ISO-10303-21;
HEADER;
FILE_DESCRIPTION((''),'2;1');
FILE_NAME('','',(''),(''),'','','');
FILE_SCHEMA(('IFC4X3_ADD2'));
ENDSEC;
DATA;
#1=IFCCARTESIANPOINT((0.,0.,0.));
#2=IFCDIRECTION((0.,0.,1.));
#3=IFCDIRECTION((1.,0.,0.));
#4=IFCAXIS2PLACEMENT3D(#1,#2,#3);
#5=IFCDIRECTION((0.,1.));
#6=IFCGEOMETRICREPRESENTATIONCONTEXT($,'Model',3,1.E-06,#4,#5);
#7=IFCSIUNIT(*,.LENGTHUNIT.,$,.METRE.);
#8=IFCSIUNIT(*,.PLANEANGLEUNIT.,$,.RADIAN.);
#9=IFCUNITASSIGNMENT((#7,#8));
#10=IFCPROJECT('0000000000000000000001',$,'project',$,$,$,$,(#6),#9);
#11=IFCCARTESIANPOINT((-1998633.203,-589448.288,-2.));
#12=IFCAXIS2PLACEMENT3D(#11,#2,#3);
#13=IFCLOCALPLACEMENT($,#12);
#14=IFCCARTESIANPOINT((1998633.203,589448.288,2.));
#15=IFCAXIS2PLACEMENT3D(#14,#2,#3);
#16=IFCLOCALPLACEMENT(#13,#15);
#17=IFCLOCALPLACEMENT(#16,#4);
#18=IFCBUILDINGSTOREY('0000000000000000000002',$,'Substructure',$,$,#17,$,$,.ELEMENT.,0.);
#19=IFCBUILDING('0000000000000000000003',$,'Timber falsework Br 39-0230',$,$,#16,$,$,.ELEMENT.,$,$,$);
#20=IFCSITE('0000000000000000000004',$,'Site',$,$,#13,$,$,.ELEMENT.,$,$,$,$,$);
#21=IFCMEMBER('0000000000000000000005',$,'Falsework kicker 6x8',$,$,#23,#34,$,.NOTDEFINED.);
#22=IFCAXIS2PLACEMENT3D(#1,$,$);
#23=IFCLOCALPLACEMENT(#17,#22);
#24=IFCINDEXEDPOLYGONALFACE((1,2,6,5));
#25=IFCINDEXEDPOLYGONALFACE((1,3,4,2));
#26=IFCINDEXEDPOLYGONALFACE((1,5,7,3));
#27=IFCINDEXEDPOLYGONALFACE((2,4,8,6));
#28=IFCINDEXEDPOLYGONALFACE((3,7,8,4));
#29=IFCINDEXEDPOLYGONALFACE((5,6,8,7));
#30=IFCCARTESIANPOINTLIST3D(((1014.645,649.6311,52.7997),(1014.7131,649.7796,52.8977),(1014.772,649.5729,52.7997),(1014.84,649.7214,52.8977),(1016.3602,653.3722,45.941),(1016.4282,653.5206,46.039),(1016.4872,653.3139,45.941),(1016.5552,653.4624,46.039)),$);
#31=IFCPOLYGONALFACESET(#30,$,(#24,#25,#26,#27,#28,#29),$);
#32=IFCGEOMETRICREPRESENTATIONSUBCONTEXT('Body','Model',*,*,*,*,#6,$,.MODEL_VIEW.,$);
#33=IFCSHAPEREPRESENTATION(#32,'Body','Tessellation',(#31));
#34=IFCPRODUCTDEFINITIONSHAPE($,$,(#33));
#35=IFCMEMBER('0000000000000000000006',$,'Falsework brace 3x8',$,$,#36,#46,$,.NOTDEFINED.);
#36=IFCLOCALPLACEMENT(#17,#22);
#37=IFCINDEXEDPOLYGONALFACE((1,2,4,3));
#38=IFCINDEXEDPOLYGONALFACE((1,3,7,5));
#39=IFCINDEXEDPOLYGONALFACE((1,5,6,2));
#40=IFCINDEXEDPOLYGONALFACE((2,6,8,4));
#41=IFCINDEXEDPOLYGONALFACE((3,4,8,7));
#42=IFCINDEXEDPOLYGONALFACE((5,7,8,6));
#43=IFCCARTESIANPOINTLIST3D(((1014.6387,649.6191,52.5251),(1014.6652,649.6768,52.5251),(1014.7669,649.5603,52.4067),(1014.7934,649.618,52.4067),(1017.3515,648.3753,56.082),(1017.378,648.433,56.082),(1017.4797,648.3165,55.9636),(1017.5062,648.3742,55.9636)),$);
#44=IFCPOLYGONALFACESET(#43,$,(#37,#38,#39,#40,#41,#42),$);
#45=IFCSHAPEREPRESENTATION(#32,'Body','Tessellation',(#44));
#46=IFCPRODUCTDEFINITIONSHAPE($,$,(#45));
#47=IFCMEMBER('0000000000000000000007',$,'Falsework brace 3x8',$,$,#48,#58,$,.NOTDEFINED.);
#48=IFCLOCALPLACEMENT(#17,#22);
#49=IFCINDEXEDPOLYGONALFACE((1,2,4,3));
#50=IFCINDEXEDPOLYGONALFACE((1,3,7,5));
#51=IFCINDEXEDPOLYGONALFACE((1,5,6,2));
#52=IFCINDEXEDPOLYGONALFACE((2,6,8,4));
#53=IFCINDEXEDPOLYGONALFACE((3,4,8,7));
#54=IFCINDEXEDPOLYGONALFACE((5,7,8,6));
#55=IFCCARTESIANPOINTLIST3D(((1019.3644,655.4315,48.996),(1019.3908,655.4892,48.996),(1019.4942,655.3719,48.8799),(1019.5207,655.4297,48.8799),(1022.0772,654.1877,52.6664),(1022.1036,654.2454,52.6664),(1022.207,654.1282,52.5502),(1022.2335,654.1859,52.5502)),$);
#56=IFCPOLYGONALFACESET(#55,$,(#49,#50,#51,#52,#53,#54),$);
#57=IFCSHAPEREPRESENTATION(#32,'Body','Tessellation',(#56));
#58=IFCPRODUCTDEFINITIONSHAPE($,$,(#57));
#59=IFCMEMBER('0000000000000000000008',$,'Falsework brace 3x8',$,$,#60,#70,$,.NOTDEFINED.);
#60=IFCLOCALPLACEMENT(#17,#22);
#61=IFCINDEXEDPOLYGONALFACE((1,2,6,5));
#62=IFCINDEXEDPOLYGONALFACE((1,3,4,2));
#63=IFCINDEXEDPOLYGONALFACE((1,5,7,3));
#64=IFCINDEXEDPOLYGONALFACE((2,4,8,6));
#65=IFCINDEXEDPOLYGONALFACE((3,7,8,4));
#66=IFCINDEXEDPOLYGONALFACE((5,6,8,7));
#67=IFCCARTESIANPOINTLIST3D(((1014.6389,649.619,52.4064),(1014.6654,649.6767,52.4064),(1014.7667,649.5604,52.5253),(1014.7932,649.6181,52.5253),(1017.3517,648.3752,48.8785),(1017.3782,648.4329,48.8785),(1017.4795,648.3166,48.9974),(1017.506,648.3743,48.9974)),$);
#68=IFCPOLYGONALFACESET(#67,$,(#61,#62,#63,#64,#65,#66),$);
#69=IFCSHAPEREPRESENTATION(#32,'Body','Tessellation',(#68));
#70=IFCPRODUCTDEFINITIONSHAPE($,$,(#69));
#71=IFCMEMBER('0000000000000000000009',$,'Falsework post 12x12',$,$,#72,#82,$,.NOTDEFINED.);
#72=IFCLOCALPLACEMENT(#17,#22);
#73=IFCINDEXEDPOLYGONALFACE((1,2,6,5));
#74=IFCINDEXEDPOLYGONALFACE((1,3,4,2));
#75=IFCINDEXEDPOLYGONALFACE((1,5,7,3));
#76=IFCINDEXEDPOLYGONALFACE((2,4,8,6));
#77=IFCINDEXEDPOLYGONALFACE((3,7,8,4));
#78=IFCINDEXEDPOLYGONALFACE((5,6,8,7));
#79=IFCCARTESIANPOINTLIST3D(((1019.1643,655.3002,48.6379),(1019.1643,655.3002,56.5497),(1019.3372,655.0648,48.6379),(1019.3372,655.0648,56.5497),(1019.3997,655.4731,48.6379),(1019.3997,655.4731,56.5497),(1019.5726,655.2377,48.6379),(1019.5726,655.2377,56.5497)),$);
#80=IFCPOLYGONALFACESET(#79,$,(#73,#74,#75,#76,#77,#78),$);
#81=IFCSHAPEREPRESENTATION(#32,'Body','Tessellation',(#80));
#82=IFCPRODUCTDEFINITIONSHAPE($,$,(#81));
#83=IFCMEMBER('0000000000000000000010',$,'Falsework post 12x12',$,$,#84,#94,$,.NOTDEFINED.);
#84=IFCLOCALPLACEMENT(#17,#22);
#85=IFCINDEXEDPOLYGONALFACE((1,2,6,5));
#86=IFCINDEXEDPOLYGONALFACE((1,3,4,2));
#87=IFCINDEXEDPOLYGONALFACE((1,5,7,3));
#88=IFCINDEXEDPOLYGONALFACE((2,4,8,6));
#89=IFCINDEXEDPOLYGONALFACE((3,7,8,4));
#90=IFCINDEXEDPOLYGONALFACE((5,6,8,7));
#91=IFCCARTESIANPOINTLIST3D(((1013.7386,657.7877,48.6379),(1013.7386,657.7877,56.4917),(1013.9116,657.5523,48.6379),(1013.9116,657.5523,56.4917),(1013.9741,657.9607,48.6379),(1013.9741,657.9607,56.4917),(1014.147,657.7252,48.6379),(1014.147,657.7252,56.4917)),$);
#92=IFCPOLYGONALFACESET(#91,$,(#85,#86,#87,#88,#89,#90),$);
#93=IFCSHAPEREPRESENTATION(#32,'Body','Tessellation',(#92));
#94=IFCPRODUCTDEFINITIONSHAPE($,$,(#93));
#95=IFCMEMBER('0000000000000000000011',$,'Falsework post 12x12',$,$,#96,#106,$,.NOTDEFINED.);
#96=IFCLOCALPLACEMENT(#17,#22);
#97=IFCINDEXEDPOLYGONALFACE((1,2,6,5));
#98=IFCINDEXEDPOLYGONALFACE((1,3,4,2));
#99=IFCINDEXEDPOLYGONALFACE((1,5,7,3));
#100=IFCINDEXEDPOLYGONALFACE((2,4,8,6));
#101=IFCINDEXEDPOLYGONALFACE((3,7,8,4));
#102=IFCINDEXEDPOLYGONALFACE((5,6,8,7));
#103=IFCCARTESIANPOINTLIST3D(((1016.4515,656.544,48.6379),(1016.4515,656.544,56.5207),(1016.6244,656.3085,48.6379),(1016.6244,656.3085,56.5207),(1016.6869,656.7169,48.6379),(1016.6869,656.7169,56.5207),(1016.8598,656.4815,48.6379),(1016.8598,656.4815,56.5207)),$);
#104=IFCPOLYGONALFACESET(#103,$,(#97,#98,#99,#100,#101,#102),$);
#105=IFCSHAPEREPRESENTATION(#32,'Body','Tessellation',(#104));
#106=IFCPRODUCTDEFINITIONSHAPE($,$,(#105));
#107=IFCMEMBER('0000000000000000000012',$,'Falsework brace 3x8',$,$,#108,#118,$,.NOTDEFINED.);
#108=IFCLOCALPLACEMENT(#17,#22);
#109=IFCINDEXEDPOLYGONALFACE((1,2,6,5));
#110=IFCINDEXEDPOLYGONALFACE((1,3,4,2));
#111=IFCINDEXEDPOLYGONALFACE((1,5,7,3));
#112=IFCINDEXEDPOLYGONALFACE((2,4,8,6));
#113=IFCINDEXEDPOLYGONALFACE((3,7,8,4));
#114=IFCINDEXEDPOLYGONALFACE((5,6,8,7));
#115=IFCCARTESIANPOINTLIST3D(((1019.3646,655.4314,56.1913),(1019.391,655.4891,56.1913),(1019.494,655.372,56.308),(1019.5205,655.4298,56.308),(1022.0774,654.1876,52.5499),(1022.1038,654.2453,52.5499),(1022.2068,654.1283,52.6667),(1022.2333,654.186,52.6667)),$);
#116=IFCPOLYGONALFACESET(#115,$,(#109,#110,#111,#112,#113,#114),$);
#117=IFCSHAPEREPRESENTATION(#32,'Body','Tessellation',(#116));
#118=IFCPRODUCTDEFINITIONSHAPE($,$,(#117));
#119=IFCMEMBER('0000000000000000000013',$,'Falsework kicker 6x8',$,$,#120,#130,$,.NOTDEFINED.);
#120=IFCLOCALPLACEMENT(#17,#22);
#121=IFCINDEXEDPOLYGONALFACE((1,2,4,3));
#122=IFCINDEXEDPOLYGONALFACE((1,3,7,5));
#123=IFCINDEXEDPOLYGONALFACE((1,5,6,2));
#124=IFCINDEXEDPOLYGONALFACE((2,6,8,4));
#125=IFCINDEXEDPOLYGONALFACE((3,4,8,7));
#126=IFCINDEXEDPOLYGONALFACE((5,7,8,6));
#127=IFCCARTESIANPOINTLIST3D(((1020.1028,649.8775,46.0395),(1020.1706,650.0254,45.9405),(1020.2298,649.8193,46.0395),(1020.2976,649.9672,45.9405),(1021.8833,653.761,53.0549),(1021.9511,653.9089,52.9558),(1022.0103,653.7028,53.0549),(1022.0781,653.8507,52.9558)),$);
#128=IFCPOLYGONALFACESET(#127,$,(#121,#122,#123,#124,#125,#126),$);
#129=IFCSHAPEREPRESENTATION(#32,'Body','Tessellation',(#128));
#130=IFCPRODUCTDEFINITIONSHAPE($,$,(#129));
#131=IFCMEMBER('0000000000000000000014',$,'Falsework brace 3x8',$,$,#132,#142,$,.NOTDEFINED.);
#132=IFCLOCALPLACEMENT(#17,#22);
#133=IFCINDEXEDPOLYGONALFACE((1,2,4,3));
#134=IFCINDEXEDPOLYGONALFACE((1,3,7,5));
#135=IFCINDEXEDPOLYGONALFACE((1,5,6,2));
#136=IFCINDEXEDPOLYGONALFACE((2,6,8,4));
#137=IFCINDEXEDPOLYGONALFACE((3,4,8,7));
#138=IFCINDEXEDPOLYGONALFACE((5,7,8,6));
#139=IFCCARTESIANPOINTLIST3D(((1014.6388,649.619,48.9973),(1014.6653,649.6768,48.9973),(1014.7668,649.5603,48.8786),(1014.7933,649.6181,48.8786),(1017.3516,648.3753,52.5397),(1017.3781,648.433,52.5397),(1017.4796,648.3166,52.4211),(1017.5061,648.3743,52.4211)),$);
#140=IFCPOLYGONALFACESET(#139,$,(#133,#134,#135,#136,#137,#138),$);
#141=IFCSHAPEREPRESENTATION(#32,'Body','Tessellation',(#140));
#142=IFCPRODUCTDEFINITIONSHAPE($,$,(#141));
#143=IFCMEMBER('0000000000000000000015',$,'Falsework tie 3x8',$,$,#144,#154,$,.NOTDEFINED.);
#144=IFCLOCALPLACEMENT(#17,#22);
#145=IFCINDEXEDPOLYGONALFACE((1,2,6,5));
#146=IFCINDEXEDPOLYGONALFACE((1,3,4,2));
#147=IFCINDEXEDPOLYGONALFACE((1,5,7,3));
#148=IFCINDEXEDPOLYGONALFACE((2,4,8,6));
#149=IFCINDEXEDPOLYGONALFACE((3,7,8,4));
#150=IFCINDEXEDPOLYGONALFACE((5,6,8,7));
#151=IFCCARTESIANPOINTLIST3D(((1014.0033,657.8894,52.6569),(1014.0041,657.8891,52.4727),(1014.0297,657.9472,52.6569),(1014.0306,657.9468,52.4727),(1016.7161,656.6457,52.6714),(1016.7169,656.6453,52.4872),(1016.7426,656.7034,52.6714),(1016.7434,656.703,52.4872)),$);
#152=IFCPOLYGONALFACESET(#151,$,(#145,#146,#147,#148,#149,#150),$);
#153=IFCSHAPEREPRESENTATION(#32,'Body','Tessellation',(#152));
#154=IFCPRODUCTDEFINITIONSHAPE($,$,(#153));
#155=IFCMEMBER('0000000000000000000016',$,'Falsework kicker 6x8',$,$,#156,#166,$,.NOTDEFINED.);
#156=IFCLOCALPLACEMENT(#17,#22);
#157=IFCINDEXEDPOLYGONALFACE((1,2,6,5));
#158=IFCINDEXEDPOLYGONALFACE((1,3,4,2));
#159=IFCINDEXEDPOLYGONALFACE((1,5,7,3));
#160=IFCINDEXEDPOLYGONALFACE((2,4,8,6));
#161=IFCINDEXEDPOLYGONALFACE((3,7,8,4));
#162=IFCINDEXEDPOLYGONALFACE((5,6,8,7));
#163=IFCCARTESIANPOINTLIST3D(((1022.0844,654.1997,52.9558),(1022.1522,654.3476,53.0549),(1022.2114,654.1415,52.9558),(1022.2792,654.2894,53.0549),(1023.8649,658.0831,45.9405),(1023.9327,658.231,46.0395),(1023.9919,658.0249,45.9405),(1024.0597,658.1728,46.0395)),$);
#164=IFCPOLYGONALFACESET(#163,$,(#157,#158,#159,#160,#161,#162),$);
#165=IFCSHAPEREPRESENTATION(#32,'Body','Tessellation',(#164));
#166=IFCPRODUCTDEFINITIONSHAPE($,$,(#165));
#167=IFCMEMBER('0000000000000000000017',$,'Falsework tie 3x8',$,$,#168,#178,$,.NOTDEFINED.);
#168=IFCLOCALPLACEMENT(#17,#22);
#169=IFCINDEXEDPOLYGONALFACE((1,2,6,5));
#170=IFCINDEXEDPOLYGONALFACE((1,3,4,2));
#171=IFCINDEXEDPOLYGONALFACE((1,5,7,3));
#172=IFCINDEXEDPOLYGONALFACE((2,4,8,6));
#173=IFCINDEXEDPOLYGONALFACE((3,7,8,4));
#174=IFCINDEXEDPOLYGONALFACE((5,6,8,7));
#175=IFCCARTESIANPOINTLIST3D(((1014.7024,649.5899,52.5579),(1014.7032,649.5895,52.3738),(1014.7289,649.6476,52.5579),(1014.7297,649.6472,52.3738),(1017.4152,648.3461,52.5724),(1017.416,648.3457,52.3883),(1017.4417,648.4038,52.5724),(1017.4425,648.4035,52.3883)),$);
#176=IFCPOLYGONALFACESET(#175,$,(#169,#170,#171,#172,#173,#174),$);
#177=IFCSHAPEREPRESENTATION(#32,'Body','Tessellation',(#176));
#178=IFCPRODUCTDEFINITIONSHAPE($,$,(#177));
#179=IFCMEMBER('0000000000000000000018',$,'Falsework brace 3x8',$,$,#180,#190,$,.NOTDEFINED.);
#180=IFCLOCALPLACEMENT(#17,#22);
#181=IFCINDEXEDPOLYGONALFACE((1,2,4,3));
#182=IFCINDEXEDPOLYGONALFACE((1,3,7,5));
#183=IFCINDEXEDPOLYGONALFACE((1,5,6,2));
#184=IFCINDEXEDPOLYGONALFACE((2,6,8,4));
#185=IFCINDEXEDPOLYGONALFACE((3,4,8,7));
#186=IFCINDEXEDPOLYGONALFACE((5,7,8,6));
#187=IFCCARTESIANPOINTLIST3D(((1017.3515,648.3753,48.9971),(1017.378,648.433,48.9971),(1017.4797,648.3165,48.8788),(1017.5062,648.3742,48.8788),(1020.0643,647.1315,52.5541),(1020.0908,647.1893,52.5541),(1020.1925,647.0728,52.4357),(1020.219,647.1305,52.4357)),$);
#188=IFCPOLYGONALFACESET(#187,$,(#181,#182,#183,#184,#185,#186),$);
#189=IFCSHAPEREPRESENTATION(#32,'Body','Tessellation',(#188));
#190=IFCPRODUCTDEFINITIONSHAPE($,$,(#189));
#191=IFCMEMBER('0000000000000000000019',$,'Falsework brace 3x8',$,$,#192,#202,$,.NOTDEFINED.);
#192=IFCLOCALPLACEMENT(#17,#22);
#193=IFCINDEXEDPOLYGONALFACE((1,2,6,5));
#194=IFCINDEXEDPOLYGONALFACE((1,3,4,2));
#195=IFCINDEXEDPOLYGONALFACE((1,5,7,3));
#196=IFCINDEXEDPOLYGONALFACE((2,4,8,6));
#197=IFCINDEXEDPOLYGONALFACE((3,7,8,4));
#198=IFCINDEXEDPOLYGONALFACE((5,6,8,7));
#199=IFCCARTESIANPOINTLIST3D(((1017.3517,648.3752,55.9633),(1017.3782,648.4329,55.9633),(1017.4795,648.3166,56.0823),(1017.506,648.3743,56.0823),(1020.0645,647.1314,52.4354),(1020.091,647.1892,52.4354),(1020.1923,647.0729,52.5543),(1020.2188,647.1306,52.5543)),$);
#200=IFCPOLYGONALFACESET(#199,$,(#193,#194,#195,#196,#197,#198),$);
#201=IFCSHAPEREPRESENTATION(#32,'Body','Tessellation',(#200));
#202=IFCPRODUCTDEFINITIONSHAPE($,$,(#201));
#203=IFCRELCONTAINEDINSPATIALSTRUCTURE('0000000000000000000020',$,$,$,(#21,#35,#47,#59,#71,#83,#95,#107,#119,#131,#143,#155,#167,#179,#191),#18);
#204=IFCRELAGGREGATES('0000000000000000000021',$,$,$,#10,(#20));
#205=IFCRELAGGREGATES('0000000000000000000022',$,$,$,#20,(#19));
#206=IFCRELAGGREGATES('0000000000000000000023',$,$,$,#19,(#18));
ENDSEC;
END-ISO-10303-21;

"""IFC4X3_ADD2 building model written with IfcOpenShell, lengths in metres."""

from ifc_helpers import new_model, si_unit, direction, frame, origin, origin_with_axes, origin_2d, place, context, subcontext, project, spatial, rectangle, extrude, element, save


model = new_model("IFC4X3_ADD2")

# Units and contexts
model_context = context("Model", 3, precision=1e-06, world=origin_with_axes(), true_north=direction((0.0, 1.0)))
body_context = subcontext(model_context, "Body", "Model", "MODEL_VIEW")
ifc_project = project(units=[si_unit("LENGTHUNIT", "METRE"), si_unit("PLANEANGLEUNIT", "RADIAN")], contexts=[model_context])

# Site, building, storey
site_placement = place(None, frame((-1998633.203, -589448.288, -2.0), z_axis=(0.0, 0.0, 1.0), x_axis=(1.0, 0.0, 0.0)))
site = spatial("IfcSite", under=ifc_project, at=site_placement, Name="Site", CompositionType="ELEMENT")
building_placement = place(site_placement, frame((1998633.203, 589448.288, 2.0), z_axis=(0.0, 0.0, 1.0), x_axis=(1.0, 0.0, 0.0)))
building = spatial("IfcBuilding", under=site, at=building_placement, Name="Timber falsework Br 39-0230", CompositionType="ELEMENT")
storey_placement = place(building_placement, origin_with_axes())
storey = spatial("IfcBuildingStorey", under=building, at=storey_placement, Name="Substructure", CompositionType="ELEMENT", Elevation=0.0)

# Members
member_1_placement = place(storey_placement, frame((1014.7425, 649.6763, 52.8487), z_axis=(0.214434, 0.467707, -0.857478), x_axis=(-0.909014, 0.416765, 0.0)))
element("IfcMember", 1, at=member_1_placement, inside=storey, Name="Falsework kicker 6x8", PredefinedType="NOTDEFINED", context=body_context, shape_type="SweptSolid", body=[
    extrude(rectangle(XDim=0.1397, YDim=0.1905, at=origin_2d()), origin(), (0.0, 0.0, 1.0), 7.9987),
])
member_2_placement = place(storey_placement, frame((1014.716, 649.6185, 52.4659), z_axis=(0.584271, -0.267877, 0.766074), x_axis=(0.416765, 0.909014, 0.0)))
element("IfcMember", 2, at=member_2_placement, inside=storey, Name="Falsework brace 3x8", PredefinedType="NOTDEFINED", context=body_context, shape_type="SweptSolid", body=[
    extrude(rectangle(XDim=0.0635, YDim=0.1841, at=origin_2d()), origin(), (0.0, 0.0, 1.0), 4.6431),
])
member_3_placement = place(storey_placement, frame((1019.4425, 655.4306, 48.9379), z_axis=(0.573468, -0.262924, 0.77589), x_axis=(0.416765, 0.909014, 0.0)))
element("IfcMember", 3, at=member_3_placement, inside=storey, Name="Falsework brace 3x8", PredefinedType="NOTDEFINED", context=body_context, shape_type="SweptSolid", body=[
    extrude(rectangle(XDim=0.0635, YDim=0.1841, at=origin_2d()), origin(), (0.0, 0.0, 1.0), 4.7305),
])
member_4_placement = place(storey_placement, frame((1014.716, 649.6185, 52.4659), z_axis=(0.587075, -0.269162, -0.763475), x_axis=(0.416765, 0.909014, 0.0)))
element("IfcMember", 4, at=member_4_placement, inside=storey, Name="Falsework brace 3x8", PredefinedType="NOTDEFINED", context=body_context, shape_type="SweptSolid", body=[
    extrude(rectangle(XDim=0.0635, YDim=0.1841, at=origin_2d()), origin(), (0.0, 0.0, 1.0), 4.6209),
])
member_5_placement = place(storey_placement, frame((1019.3684, 655.2689, 48.6379), z_axis=(0.0, 0.0, 1.0), x_axis=(-0.805928, -0.592013, 0.0)))
element("IfcMember", 5, at=member_5_placement, inside=storey, Name="Falsework post 12x12", PredefinedType="NOTDEFINED", context=body_context, shape_type="SweptSolid", body=[
    extrude(rectangle(XDim=0.2921, YDim=0.2921, at=origin_2d()), origin(), (0.0, 0.0, 1.0), 7.9117),
])
member_6_placement = place(storey_placement, frame((1013.9428, 657.7565, 48.6379), z_axis=(0.0, 0.0, 1.0), x_axis=(-0.805928, -0.592013, 0.0)))
element("IfcMember", 6, at=member_6_placement, inside=storey, Name="Falsework post 12x12", PredefinedType="NOTDEFINED", context=body_context, shape_type="SweptSolid", body=[
    extrude(rectangle(XDim=0.2921, YDim=0.2921, at=origin_2d()), origin(), (0.0, 0.0, 1.0), 7.8537),
])
member_7_placement = place(storey_placement, frame((1016.6556, 656.5127, 48.6379), z_axis=(0.0, 0.0, 1.0), x_axis=(-0.805928, -0.592013, 0.0)))
element("IfcMember", 7, at=member_7_placement, inside=storey, Name="Falsework post 12x12", PredefinedType="NOTDEFINED", context=body_context, shape_type="SweptSolid", body=[
    extrude(rectangle(XDim=0.2921, YDim=0.2921, at=origin_2d()), origin(), (0.0, 0.0, 1.0), 7.8827),
])
member_8_placement = place(storey_placement, frame((1019.4425, 655.4306, 56.2497), z_axis=(0.576205, -0.264179, -0.773432), x_axis=(0.416765, 0.909014, 0.0)))
element("IfcMember", 8, at=member_8_placement, inside=storey, Name="Falsework brace 3x8", PredefinedType="NOTDEFINED", context=body_context, shape_type="SweptSolid", body=[
    extrude(rectangle(XDim=0.0635, YDim=0.1841, at=origin_2d()), origin(), (0.0, 0.0, 1.0), 4.7081),
])
member_9_placement = place(storey_placement, frame((1021.9807, 653.8058, 53.0053), z_axis=(-0.216768, -0.472796, -0.854093), x_axis=(0.909014, -0.416765, 0.0)))
element("IfcMember", 9, at=member_9_placement, inside=storey, Name="Falsework kicker 6x8", PredefinedType="NOTDEFINED", context=body_context, shape_type="SweptSolid", body=[
    extrude(rectangle(XDim=0.1397, YDim=0.1905, at=origin_2d()), origin(), (0.0, 0.0, 1.0), 8.2138),
])
member_10_placement = place(storey_placement, frame((1014.716, 649.6185, 48.9379), z_axis=(0.585671, -0.268519, 0.764779), x_axis=(0.416765, 0.909014, 0.0)))
element("IfcMember", 10, at=member_10_placement, inside=storey, Name="Falsework brace 3x8", PredefinedType="NOTDEFINED", context=body_context, shape_type="SweptSolid", body=[
    extrude(rectangle(XDim=0.0635, YDim=0.1841, at=origin_2d()), origin(), (0.0, 0.0, 1.0), 4.632),
])
member_11_placement = place(storey_placement, frame((1014.0169, 657.9181, 52.5648), z_axis=(0.909003, -0.41676, 0.004859), x_axis=(0.416765, 0.909014, 0.0)))
element("IfcMember", 11, at=member_11_placement, inside=storey, Name="Falsework tie 3x8", PredefinedType="NOTDEFINED", context=body_context, shape_type="SweptSolid", body=[
    extrude(rectangle(XDim=0.0635, YDim=0.1841, at=origin_2d()), origin(), (0.0, 0.0, 1.0), 2.9844),
])
member_12_placement = place(storey_placement, frame((1022.1818, 654.2445, 53.0053), z_axis=(0.216768, 0.472796, -0.854093), x_axis=(-0.909014, 0.416765, 0.0)))
element("IfcMember", 12, at=member_12_placement, inside=storey, Name="Falsework kicker 6x8", PredefinedType="NOTDEFINED", context=body_context, shape_type="SweptSolid", body=[
    extrude(rectangle(XDim=0.1397, YDim=0.1905, at=origin_2d()), origin(), (0.0, 0.0, 1.0), 8.2138),
])
member_13_placement = place(storey_placement, frame((1014.716, 649.6185, 52.4659), z_axis=(0.909003, -0.41676, 0.004859), x_axis=(0.416765, 0.909014, 0.0)))
element("IfcMember", 13, at=member_13_placement, inside=storey, Name="Falsework tie 3x8", PredefinedType="NOTDEFINED", context=body_context, shape_type="SweptSolid", body=[
    extrude(rectangle(XDim=0.0635, YDim=0.1841, at=origin_2d()), origin(), (0.0, 0.0, 1.0), 2.9844),
])
member_14_placement = place(storey_placement, frame((1017.4289, 648.3748, 48.9379), z_axis=(0.584271, -0.267877, 0.766074), x_axis=(0.416765, 0.909014, 0.0)))
element("IfcMember", 14, at=member_14_placement, inside=storey, Name="Falsework brace 3x8", PredefinedType="NOTDEFINED", context=body_context, shape_type="SweptSolid", body=[
    extrude(rectangle(XDim=0.0635, YDim=0.1841, at=origin_2d()), origin(), (0.0, 0.0, 1.0), 4.6431),
])
member_15_placement = place(storey_placement, frame((1017.4289, 648.3748, 56.0228), z_axis=(0.587075, -0.269162, -0.763475), x_axis=(0.416765, 0.909014, 0.0)))
element("IfcMember", 15, at=member_15_placement, inside=storey, Name="Falsework brace 3x8", PredefinedType="NOTDEFINED", context=body_context, shape_type="SweptSolid", body=[
    extrude(rectangle(XDim=0.0635, YDim=0.1841, at=origin_2d()), origin(), (0.0, 0.0, 1.0), 4.6209),
])

save(model, "model.ifc")
